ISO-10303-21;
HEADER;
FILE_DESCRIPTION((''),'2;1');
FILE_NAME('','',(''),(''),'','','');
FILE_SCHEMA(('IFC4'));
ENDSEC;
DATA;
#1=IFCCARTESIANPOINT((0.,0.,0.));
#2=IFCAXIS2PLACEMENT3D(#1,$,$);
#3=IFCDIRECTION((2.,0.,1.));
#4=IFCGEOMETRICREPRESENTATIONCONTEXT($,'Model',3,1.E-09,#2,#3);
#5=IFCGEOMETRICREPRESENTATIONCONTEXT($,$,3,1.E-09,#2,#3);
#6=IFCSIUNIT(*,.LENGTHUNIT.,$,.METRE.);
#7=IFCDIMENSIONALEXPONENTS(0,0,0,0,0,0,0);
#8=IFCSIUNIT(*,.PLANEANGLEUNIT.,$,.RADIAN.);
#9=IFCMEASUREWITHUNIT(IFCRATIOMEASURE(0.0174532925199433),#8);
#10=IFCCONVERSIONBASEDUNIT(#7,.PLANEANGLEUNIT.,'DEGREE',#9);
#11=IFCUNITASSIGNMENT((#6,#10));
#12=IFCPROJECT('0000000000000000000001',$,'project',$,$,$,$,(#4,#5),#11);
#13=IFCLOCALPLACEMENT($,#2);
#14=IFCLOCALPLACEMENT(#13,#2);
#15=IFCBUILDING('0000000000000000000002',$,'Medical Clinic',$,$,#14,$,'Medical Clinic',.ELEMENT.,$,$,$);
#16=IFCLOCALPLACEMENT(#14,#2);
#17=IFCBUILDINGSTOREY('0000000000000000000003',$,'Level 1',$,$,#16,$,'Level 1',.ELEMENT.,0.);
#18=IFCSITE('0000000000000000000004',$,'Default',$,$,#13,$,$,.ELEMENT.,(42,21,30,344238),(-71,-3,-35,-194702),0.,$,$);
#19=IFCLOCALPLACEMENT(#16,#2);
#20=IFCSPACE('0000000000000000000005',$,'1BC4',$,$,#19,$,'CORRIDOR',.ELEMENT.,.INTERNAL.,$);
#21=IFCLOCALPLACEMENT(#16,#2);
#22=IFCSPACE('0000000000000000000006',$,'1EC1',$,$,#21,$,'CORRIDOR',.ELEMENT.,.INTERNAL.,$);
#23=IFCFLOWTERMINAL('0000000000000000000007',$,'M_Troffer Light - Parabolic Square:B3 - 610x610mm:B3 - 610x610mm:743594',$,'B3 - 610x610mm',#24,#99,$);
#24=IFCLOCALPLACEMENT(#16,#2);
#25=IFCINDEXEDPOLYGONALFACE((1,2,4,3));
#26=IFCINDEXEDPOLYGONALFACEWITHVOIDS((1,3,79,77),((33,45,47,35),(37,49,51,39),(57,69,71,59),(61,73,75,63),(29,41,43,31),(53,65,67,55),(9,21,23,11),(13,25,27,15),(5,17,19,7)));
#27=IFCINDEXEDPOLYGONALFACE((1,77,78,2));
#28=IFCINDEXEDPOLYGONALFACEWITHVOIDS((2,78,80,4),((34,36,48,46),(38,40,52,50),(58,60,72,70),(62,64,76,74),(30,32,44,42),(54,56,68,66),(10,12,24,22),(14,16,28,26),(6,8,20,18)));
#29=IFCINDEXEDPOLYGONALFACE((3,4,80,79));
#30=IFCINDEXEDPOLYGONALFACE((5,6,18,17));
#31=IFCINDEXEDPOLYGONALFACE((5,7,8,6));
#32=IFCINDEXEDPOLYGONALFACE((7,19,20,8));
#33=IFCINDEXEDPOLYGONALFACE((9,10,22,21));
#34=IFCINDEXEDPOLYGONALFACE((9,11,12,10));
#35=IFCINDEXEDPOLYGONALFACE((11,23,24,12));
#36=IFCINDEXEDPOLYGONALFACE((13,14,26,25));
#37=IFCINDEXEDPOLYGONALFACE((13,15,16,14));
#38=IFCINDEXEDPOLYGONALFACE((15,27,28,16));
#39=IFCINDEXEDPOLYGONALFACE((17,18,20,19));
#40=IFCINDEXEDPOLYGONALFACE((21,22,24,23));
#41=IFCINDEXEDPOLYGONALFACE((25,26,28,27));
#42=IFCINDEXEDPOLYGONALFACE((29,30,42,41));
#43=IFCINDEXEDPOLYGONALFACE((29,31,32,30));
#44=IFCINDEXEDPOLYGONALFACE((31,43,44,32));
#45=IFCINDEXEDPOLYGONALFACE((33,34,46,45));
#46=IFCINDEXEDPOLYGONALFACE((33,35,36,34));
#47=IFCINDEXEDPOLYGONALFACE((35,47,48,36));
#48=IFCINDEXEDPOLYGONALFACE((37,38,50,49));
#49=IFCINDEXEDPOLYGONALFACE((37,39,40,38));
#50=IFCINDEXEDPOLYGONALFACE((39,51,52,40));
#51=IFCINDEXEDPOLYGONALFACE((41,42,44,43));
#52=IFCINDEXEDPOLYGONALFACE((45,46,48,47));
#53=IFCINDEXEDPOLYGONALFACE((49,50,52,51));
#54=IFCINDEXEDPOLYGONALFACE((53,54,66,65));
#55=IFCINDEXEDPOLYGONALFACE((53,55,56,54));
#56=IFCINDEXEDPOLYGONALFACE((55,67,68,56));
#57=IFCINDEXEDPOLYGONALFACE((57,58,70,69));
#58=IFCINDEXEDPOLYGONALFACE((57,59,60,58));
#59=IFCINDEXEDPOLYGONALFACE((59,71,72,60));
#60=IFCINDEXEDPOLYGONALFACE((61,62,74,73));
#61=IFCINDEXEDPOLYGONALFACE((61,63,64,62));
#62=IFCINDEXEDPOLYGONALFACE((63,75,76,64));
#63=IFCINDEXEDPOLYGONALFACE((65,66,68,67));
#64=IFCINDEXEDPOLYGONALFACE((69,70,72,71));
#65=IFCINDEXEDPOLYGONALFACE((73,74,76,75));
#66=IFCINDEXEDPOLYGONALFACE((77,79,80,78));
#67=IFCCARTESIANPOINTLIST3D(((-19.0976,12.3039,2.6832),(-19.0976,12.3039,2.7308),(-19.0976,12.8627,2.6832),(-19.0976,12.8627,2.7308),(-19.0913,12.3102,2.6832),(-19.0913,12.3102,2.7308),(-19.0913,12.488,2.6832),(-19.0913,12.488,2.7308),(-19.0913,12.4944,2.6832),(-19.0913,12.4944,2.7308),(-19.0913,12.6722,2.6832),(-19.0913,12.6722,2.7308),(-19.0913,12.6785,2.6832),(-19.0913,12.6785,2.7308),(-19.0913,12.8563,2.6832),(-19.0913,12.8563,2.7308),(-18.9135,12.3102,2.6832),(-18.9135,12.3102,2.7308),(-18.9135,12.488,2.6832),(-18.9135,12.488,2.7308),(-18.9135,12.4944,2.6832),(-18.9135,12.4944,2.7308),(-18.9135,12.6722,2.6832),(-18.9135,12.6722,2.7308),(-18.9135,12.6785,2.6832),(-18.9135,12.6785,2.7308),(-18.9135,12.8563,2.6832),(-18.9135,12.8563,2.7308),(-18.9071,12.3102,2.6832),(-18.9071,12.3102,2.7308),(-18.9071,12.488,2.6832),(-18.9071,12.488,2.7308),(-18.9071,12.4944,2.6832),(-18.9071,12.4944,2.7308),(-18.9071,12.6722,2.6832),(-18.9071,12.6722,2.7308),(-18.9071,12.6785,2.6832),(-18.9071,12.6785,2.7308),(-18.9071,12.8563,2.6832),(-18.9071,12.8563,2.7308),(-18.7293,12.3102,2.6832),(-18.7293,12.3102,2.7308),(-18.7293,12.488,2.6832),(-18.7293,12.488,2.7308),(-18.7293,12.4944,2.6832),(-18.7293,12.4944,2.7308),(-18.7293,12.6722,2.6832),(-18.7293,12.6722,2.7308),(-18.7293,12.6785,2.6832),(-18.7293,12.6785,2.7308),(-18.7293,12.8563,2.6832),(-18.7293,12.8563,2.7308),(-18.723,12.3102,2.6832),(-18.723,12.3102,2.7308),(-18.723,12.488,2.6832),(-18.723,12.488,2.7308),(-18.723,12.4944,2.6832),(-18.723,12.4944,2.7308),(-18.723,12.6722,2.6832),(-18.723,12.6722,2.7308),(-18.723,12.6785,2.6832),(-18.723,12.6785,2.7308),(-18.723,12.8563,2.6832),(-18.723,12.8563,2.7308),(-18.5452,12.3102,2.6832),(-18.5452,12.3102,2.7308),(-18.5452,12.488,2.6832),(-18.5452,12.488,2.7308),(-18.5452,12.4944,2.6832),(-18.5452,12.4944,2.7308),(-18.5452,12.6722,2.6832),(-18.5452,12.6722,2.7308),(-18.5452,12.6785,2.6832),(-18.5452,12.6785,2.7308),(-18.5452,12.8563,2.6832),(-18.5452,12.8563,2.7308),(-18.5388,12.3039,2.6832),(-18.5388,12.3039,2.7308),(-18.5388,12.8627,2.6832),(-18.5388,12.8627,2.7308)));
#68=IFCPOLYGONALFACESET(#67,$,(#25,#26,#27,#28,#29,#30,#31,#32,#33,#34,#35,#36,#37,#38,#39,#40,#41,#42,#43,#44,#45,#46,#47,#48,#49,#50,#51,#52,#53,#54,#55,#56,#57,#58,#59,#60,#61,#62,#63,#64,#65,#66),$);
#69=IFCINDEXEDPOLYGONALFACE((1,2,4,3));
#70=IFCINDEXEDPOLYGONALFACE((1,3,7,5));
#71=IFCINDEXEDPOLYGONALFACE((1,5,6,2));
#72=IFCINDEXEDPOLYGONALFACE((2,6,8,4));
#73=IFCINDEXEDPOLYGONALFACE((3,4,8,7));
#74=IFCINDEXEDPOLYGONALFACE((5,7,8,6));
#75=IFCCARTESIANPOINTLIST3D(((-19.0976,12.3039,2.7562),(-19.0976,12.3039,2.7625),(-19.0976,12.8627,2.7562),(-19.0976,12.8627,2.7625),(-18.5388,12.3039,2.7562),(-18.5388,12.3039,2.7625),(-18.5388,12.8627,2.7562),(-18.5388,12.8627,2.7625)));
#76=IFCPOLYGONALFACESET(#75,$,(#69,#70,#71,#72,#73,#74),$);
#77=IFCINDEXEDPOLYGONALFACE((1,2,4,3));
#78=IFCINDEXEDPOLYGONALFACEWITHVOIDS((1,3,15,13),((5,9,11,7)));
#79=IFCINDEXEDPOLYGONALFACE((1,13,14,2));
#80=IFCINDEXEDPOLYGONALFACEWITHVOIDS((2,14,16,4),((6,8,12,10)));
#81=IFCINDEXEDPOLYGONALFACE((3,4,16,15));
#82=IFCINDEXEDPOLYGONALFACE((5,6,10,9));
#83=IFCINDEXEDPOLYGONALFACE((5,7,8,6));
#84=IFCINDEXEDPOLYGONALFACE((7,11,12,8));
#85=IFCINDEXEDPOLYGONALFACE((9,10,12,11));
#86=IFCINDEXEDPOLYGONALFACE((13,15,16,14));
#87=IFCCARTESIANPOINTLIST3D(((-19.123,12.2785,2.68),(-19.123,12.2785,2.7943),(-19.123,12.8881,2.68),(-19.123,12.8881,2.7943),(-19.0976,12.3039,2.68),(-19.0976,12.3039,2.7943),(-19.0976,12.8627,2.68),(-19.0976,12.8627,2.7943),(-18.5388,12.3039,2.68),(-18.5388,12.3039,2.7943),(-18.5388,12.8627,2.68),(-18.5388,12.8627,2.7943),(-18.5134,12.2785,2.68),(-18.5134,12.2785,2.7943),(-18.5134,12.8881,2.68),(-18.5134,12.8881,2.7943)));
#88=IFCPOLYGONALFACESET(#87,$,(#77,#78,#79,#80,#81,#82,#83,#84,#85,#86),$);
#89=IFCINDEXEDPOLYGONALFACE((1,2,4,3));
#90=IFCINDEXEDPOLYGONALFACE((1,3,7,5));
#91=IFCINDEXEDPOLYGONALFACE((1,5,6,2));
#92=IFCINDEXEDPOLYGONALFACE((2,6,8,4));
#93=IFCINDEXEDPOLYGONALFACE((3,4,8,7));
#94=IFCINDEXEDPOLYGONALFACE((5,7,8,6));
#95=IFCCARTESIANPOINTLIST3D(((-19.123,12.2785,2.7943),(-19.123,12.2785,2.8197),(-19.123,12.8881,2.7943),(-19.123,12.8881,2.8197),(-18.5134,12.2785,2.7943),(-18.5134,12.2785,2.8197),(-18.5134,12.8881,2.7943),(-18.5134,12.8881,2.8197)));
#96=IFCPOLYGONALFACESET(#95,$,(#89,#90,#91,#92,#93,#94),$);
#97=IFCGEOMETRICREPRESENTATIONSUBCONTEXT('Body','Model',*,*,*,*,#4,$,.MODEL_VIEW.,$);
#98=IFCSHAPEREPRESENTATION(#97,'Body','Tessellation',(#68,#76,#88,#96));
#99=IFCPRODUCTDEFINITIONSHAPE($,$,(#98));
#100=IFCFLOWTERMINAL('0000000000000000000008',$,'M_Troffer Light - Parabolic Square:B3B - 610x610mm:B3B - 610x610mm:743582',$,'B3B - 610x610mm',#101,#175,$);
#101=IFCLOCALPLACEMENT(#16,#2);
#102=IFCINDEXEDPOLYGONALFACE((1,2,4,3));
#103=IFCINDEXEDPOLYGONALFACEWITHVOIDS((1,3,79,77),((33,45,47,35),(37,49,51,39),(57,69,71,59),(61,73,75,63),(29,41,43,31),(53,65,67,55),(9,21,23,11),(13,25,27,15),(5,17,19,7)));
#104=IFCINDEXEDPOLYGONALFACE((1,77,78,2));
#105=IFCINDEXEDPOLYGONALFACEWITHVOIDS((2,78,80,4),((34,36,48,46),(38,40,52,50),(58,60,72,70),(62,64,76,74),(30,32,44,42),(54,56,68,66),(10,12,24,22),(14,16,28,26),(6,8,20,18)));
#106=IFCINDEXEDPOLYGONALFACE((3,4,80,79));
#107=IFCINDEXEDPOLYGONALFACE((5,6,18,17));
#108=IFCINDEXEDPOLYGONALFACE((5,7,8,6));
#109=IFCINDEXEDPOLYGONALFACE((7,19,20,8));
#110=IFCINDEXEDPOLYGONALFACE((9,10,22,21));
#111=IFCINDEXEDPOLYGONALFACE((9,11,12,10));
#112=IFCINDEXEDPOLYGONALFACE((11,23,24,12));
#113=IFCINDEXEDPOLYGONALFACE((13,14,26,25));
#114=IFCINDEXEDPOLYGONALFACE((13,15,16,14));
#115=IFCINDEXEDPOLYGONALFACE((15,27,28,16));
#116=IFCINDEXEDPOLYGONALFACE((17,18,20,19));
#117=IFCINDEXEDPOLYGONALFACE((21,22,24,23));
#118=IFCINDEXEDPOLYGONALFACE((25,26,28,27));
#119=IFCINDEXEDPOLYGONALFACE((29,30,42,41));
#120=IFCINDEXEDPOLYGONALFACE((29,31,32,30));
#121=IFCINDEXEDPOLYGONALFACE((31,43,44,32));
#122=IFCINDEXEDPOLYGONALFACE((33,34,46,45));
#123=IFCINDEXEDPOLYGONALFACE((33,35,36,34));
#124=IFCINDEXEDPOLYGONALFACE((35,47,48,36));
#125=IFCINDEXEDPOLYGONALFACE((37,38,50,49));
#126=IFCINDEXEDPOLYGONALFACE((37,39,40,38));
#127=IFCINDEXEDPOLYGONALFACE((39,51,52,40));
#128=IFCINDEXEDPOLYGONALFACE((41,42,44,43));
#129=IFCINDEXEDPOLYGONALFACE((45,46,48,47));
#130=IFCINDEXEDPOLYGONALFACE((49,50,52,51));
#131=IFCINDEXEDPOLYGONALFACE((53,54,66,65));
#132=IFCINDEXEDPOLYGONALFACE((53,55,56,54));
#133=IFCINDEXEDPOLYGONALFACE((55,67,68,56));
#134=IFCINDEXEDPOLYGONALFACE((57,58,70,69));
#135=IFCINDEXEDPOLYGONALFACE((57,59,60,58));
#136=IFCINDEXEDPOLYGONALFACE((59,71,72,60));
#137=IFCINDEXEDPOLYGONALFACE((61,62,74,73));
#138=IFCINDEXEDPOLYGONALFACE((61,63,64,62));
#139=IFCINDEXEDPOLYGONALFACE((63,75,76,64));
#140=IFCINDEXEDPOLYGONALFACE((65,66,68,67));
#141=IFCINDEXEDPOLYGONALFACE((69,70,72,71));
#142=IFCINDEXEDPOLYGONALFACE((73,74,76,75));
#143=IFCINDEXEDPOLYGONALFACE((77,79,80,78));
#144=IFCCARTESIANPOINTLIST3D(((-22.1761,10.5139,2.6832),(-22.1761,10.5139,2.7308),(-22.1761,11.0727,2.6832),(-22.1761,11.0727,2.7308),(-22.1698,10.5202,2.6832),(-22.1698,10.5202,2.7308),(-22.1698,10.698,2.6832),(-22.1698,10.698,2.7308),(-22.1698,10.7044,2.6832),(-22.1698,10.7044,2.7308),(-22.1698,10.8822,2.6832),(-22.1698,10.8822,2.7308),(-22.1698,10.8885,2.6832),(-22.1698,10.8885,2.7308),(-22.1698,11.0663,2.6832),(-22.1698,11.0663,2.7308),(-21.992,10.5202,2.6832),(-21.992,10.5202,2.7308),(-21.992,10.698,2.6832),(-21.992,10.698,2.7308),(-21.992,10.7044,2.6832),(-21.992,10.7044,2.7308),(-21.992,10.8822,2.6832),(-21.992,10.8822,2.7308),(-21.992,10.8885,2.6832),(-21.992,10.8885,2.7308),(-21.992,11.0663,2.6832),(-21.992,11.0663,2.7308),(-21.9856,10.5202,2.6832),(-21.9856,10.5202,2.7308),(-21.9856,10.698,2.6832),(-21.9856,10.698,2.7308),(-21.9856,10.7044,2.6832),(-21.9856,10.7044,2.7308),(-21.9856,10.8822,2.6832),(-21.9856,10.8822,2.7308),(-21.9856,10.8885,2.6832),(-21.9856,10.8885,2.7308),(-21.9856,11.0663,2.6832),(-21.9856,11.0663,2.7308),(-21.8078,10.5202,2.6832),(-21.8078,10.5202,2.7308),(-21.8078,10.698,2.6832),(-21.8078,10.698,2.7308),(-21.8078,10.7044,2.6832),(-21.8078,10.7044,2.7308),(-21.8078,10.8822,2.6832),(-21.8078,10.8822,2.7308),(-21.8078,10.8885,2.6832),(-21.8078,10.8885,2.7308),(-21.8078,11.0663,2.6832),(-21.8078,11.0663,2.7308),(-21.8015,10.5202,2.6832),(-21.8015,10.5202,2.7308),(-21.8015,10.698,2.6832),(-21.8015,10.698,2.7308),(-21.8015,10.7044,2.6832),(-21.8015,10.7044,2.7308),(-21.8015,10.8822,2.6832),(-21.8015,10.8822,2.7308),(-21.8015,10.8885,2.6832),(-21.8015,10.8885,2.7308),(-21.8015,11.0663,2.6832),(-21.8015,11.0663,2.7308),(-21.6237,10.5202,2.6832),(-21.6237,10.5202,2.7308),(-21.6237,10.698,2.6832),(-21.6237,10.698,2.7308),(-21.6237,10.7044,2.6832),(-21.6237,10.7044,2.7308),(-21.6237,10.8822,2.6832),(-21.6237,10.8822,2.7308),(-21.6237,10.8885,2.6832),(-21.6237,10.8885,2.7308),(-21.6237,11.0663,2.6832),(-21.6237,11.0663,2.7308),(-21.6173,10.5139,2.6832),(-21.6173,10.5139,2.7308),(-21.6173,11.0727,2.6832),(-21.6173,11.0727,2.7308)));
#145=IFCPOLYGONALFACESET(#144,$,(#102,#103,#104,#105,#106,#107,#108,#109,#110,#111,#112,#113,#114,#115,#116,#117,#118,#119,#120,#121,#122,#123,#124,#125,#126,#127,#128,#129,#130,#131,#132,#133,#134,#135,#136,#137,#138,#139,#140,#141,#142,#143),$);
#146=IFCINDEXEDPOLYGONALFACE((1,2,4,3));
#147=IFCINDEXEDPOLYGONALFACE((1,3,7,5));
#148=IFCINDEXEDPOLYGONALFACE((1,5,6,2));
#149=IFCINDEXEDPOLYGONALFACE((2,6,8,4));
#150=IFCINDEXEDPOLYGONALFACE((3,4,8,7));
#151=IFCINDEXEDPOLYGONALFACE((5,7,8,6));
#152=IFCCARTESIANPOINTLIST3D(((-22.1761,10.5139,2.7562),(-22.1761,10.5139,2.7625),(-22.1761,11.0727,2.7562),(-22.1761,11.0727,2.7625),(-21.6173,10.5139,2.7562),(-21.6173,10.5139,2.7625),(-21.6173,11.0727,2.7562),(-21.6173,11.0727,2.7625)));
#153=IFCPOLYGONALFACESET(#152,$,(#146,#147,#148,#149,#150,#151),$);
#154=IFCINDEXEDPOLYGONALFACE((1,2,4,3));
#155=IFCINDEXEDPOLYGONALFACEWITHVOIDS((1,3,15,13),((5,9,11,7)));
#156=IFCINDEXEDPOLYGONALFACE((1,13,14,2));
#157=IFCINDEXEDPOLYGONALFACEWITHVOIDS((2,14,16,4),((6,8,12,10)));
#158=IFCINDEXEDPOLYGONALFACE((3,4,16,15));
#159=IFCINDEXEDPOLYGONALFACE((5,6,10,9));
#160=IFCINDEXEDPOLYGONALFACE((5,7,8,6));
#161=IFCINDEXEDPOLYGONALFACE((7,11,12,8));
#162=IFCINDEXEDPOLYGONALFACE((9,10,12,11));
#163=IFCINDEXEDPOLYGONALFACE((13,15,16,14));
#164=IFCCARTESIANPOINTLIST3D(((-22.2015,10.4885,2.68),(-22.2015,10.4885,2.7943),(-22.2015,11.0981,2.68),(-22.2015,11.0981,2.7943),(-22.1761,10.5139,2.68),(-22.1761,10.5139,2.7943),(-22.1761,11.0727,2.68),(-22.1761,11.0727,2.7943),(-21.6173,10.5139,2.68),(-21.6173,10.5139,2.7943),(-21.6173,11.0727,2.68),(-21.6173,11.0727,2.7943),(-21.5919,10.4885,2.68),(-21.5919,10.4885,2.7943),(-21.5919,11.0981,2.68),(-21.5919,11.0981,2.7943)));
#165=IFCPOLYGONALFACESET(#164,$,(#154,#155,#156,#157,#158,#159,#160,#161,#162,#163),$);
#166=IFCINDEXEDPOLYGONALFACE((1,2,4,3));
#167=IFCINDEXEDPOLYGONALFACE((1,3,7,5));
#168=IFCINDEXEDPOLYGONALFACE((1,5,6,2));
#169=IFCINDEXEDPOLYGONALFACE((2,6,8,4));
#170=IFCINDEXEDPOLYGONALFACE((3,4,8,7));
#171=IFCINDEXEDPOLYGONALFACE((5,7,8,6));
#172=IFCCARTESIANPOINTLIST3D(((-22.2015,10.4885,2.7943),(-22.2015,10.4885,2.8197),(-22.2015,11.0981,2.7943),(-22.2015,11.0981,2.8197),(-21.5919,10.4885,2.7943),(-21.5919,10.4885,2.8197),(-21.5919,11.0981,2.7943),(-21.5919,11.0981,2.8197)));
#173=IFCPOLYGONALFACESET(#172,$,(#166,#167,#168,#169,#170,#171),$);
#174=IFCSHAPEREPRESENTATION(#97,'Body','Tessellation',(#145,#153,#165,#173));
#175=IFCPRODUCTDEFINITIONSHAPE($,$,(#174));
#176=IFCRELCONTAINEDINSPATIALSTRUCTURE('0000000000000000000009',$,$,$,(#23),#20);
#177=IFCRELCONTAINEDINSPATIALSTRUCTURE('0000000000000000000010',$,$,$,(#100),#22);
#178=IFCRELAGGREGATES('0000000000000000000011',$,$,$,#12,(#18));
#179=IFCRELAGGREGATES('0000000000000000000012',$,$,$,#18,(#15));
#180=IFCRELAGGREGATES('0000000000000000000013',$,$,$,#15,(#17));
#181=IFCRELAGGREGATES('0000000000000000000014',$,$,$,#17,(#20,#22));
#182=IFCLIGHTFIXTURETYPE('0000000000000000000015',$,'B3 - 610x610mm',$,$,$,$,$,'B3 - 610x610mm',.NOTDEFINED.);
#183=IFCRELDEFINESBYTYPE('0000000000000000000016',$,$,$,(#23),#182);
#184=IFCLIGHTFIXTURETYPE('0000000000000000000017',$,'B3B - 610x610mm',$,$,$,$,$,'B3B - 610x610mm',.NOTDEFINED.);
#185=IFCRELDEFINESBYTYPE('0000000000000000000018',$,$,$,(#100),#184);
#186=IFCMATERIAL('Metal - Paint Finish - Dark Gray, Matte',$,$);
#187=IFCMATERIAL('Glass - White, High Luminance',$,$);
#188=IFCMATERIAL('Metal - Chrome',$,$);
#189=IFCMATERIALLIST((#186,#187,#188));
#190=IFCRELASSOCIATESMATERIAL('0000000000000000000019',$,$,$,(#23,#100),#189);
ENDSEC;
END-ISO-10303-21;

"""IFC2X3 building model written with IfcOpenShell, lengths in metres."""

from ifc_helpers import new_model, entity, si_unit, converted_unit, direction, frame, origin, origin_2d_with_axis, place, context, subcontext, project, spatial, polyline, rectangle, outline, extrude, source, transform, mapped, material, material_list, type_object, type_shapes, element, save


model = new_model("IFC2X3")

# Units and contexts
model_context = context("Model", 3, precision=1e-09, world=origin(), true_north=direction((2.0, 0.0, 1.0)))
context_of_model = context(None, 3, precision=1e-09, world=origin(), true_north=direction((2.0, 0.0, 1.0)))
body_context = subcontext(model_context, "Body", "Model", "MODEL_VIEW")
ifc_project = project(units=[si_unit("LENGTHUNIT", "METRE"), converted_unit("PLANEANGLEUNIT", "DEGREE", entity("IfcRatioMeasure", 0.0174532925199433), si_unit("PLANEANGLEUNIT", "RADIAN"), dimensions=[0, 0, 0, 0, 0, 0, 0])], contexts=[model_context, context_of_model])

# Site, building, storey
site_placement = place(None, origin())
site = spatial("IfcSite", under=ifc_project, at=site_placement, Name="Default", CompositionType="ELEMENT", RefLatitude=(42, 21, 30, 344238), RefLongitude=(-71, -3, -35, -194702), RefElevation=0.0)
building_placement = place(site_placement, origin())
building = spatial("IfcBuilding", under=site, at=building_placement, Name="Medical Clinic", LongName="Medical Clinic", CompositionType="ELEMENT")
storey_placement = place(building_placement, origin())
storey = spatial("IfcBuildingStorey", under=building, at=storey_placement, Name="Level 1", LongName="Level 1", CompositionType="ELEMENT", Elevation=0.0)

# Shared definitions
space_1_placement = place(storey_placement, origin())
space_1 = spatial("IfcSpace", under=storey, at=space_1_placement, Name="1BC4", LongName="CORRIDOR", CompositionType="ELEMENT", InteriorOrExteriorSpace="INTERNAL")

# Shared definitions
space_2_placement = place(storey_placement, origin())
space_2 = spatial("IfcSpace", under=storey, at=space_2_placement, Name="1EC1", LongName="CORRIDOR", CompositionType="ELEMENT", InteriorOrExteriorSpace="INTERNAL")

# Flow terminals
ifc_material_1 = material(Name="Metal - Paint Finish - Dark Gray, Matte")
ifc_material_2 = material(Name="Glass - White, High Luminance")
ifc_material_3 = material(Name="Metal - Chrome")
ifc_material_list_1 = material_list([ifc_material_1, ifc_material_2, ifc_material_3])
light_fixture_type_1 = type_object("IfcLightFixtureType", Name="B3 - 610x610mm", ElementType="B3 - 610x610mm", PredefinedType="NOTDEFINED")
shared_shape_1 = source(origin(), body_context, "Body", "SweptSolid", [
    extrude(outline(polyline([(-0.2794, -0.2794), (0.2794, -0.2794), (0.2794, 0.2794), (-0.2794, 0.2794), (-0.2794, -0.2794)]), holes=[polyline([(-0.0952, 0.0953), (-0.273, 0.0953), (-0.273, 0.2731), (-0.0952, 0.2731), (-0.0952, 0.0953)]), polyline([(0.2731, 0.0953), (0.0953, 0.0953), (0.0953, 0.2731), (0.2731, 0.2731), (0.2731, 0.0953)]), polyline([(-0.0889, 0.2731), (0.0889, 0.2731), (0.0889, 0.0953), (-0.0889, 0.0953), (-0.0889, 0.2731)]), polyline([(0.2731, -0.273), (0.0953, -0.273), (0.0953, -0.0952), (0.2731, -0.0952), (0.2731, -0.273)]), polyline([(0.0889, -0.273), (-0.0889, -0.273), (-0.0889, -0.0952), (0.0889, -0.0952), (0.0889, -0.273)]), polyline([(-0.0952, -0.273), (-0.273, -0.273), (-0.273, -0.0952), (-0.0952, -0.0952), (-0.0952, -0.273)]), polyline([(-0.0952, -0.0889), (-0.273, -0.0889), (-0.273, 0.0889), (-0.0952, 0.0889), (-0.0952, -0.0889)]), polyline([(0.0889, -0.0889), (-0.0889, -0.0889), (-0.0889, 0.0889), (0.0889, 0.0889), (0.0889, -0.0889)]), polyline([(0.2731, -0.0889), (0.0953, -0.0889), (0.0953, 0.0889), (0.2731, 0.0889), (0.2731, -0.0889)])]), frame((0.0, -0.3048, -0.0508), z_axis=(0.0, 0.0, 1.0), x_axis=(-1.0, 0.0, 0.0)), (0.0, 0.0, 1.0), 0.0476),
    extrude(rectangle(XDim=0.5588, YDim=0.5588, at=origin_2d_with_axis()), frame((0.0, -0.3048, -0.0825), z_axis=(0.0, 0.0, 1.0), x_axis=(-1.0, 0.0, 0.0)), (0.0, 0.0, 1.0), 0.0064),
    extrude(outline(polyline([(-0.3048, -0.3048), (0.3048, -0.3048), (0.3048, 0.3048), (-0.3048, 0.3048), (-0.3048, -0.3048)]), holes=[polyline([(0.2794, 0.2794), (0.2794, -0.2794), (-0.2794, -0.2794), (-0.2794, 0.2794), (0.2794, 0.2794)])]), frame((0.0, -0.3048, -0.1143)), (0.0, 0.0, 1.0), 0.1143),
    extrude(rectangle(XDim=0.6096, YDim=0.6096, at=origin_2d_with_axis()), frame((0.0, -0.3048, -0.1397), z_axis=(0.0, 0.0, 1.0), x_axis=(-1.0, 0.0, 0.0)), (0.0, 0.0, 1.0), 0.0254),
])
type_shapes(light_fixture_type_1, [shared_shape_1])
flow_terminal_1_placement = place(space_1_placement, frame((-18.8182, 12.2785, 2.68), z_axis=(0.0, 0.0, -1.0), x_axis=(1.0, 0.0, 0.0)))
element("IfcFlowTerminal", 1, at=flow_terminal_1_placement, inside=space_1, type_object=light_fixture_type_1, material=ifc_material_list_1, Name="M_Troffer Light - Parabolic Square:B3 - 610x610mm:B3 - 610x610mm:743594", ObjectType="B3 - 610x610mm", context=body_context, shape_type="MappedRepresentation", body=[
    mapped(shared_shape_1, transform((0.0, 0.0, 0.0), scale=1.0)),
])
light_fixture_type_2 = type_object("IfcLightFixtureType", Name="B3B - 610x610mm", ElementType="B3B - 610x610mm", PredefinedType="NOTDEFINED")
shared_shape_2 = source(origin(), body_context, "Body", "SweptSolid", [
    extrude(outline(polyline([(-0.2794, -0.2794), (0.2794, -0.2794), (0.2794, 0.2794), (-0.2794, 0.2794), (-0.2794, -0.2794)]), holes=[polyline([(-0.0952, 0.0953), (-0.273, 0.0953), (-0.273, 0.2731), (-0.0952, 0.2731), (-0.0952, 0.0953)]), polyline([(0.2731, 0.0953), (0.0953, 0.0953), (0.0953, 0.2731), (0.2731, 0.2731), (0.2731, 0.0953)]), polyline([(-0.0889, 0.2731), (0.0889, 0.2731), (0.0889, 0.0953), (-0.0889, 0.0953), (-0.0889, 0.2731)]), polyline([(0.2731, -0.273), (0.0953, -0.273), (0.0953, -0.0952), (0.2731, -0.0952), (0.2731, -0.273)]), polyline([(0.0889, -0.273), (-0.0889, -0.273), (-0.0889, -0.0952), (0.0889, -0.0952), (0.0889, -0.273)]), polyline([(-0.0952, -0.273), (-0.273, -0.273), (-0.273, -0.0952), (-0.0952, -0.0952), (-0.0952, -0.273)]), polyline([(-0.0952, -0.0889), (-0.273, -0.0889), (-0.273, 0.0889), (-0.0952, 0.0889), (-0.0952, -0.0889)]), polyline([(0.0889, -0.0889), (-0.0889, -0.0889), (-0.0889, 0.0889), (0.0889, 0.0889), (0.0889, -0.0889)]), polyline([(0.2731, -0.0889), (0.0953, -0.0889), (0.0953, 0.0889), (0.2731, 0.0889), (0.2731, -0.0889)])]), frame((0.0, -0.3048, -0.0508), z_axis=(0.0, 0.0, 1.0), x_axis=(-1.0, 0.0, 0.0)), (0.0, 0.0, 1.0), 0.0476),
    extrude(rectangle(XDim=0.5588, YDim=0.5588, at=origin_2d_with_axis()), frame((0.0, -0.3048, -0.0825), z_axis=(0.0, 0.0, 1.0), x_axis=(-1.0, 0.0, 0.0)), (0.0, 0.0, 1.0), 0.0064),
    extrude(outline(polyline([(-0.3048, -0.3048), (0.3048, -0.3048), (0.3048, 0.3048), (-0.3048, 0.3048), (-0.3048, -0.3048)]), holes=[polyline([(0.2794, 0.2794), (0.2794, -0.2794), (-0.2794, -0.2794), (-0.2794, 0.2794), (0.2794, 0.2794)])]), frame((0.0, -0.3048, -0.1143)), (0.0, 0.0, 1.0), 0.1143),
    extrude(rectangle(XDim=0.6096, YDim=0.6096, at=origin_2d_with_axis()), frame((0.0, -0.3048, -0.1397), z_axis=(0.0, 0.0, 1.0), x_axis=(-1.0, 0.0, 0.0)), (0.0, 0.0, 1.0), 0.0254),
])
type_shapes(light_fixture_type_2, [shared_shape_2])
flow_terminal_2_placement = place(space_2_placement, frame((-21.8967, 10.4885, 2.68), z_axis=(0.0, 0.0, -1.0), x_axis=(1.0, 0.0, 0.0)))
element("IfcFlowTerminal", 2, at=flow_terminal_2_placement, inside=space_2, type_object=light_fixture_type_2, material=ifc_material_list_1, Name="M_Troffer Light - Parabolic Square:B3B - 610x610mm:B3B - 610x610mm:743582", ObjectType="B3B - 610x610mm", context=body_context, shape_type="MappedRepresentation", body=[
    mapped(shared_shape_2, transform((0.0, 0.0, 0.0), scale=1.0)),
])

save(model, "model.ifc")
